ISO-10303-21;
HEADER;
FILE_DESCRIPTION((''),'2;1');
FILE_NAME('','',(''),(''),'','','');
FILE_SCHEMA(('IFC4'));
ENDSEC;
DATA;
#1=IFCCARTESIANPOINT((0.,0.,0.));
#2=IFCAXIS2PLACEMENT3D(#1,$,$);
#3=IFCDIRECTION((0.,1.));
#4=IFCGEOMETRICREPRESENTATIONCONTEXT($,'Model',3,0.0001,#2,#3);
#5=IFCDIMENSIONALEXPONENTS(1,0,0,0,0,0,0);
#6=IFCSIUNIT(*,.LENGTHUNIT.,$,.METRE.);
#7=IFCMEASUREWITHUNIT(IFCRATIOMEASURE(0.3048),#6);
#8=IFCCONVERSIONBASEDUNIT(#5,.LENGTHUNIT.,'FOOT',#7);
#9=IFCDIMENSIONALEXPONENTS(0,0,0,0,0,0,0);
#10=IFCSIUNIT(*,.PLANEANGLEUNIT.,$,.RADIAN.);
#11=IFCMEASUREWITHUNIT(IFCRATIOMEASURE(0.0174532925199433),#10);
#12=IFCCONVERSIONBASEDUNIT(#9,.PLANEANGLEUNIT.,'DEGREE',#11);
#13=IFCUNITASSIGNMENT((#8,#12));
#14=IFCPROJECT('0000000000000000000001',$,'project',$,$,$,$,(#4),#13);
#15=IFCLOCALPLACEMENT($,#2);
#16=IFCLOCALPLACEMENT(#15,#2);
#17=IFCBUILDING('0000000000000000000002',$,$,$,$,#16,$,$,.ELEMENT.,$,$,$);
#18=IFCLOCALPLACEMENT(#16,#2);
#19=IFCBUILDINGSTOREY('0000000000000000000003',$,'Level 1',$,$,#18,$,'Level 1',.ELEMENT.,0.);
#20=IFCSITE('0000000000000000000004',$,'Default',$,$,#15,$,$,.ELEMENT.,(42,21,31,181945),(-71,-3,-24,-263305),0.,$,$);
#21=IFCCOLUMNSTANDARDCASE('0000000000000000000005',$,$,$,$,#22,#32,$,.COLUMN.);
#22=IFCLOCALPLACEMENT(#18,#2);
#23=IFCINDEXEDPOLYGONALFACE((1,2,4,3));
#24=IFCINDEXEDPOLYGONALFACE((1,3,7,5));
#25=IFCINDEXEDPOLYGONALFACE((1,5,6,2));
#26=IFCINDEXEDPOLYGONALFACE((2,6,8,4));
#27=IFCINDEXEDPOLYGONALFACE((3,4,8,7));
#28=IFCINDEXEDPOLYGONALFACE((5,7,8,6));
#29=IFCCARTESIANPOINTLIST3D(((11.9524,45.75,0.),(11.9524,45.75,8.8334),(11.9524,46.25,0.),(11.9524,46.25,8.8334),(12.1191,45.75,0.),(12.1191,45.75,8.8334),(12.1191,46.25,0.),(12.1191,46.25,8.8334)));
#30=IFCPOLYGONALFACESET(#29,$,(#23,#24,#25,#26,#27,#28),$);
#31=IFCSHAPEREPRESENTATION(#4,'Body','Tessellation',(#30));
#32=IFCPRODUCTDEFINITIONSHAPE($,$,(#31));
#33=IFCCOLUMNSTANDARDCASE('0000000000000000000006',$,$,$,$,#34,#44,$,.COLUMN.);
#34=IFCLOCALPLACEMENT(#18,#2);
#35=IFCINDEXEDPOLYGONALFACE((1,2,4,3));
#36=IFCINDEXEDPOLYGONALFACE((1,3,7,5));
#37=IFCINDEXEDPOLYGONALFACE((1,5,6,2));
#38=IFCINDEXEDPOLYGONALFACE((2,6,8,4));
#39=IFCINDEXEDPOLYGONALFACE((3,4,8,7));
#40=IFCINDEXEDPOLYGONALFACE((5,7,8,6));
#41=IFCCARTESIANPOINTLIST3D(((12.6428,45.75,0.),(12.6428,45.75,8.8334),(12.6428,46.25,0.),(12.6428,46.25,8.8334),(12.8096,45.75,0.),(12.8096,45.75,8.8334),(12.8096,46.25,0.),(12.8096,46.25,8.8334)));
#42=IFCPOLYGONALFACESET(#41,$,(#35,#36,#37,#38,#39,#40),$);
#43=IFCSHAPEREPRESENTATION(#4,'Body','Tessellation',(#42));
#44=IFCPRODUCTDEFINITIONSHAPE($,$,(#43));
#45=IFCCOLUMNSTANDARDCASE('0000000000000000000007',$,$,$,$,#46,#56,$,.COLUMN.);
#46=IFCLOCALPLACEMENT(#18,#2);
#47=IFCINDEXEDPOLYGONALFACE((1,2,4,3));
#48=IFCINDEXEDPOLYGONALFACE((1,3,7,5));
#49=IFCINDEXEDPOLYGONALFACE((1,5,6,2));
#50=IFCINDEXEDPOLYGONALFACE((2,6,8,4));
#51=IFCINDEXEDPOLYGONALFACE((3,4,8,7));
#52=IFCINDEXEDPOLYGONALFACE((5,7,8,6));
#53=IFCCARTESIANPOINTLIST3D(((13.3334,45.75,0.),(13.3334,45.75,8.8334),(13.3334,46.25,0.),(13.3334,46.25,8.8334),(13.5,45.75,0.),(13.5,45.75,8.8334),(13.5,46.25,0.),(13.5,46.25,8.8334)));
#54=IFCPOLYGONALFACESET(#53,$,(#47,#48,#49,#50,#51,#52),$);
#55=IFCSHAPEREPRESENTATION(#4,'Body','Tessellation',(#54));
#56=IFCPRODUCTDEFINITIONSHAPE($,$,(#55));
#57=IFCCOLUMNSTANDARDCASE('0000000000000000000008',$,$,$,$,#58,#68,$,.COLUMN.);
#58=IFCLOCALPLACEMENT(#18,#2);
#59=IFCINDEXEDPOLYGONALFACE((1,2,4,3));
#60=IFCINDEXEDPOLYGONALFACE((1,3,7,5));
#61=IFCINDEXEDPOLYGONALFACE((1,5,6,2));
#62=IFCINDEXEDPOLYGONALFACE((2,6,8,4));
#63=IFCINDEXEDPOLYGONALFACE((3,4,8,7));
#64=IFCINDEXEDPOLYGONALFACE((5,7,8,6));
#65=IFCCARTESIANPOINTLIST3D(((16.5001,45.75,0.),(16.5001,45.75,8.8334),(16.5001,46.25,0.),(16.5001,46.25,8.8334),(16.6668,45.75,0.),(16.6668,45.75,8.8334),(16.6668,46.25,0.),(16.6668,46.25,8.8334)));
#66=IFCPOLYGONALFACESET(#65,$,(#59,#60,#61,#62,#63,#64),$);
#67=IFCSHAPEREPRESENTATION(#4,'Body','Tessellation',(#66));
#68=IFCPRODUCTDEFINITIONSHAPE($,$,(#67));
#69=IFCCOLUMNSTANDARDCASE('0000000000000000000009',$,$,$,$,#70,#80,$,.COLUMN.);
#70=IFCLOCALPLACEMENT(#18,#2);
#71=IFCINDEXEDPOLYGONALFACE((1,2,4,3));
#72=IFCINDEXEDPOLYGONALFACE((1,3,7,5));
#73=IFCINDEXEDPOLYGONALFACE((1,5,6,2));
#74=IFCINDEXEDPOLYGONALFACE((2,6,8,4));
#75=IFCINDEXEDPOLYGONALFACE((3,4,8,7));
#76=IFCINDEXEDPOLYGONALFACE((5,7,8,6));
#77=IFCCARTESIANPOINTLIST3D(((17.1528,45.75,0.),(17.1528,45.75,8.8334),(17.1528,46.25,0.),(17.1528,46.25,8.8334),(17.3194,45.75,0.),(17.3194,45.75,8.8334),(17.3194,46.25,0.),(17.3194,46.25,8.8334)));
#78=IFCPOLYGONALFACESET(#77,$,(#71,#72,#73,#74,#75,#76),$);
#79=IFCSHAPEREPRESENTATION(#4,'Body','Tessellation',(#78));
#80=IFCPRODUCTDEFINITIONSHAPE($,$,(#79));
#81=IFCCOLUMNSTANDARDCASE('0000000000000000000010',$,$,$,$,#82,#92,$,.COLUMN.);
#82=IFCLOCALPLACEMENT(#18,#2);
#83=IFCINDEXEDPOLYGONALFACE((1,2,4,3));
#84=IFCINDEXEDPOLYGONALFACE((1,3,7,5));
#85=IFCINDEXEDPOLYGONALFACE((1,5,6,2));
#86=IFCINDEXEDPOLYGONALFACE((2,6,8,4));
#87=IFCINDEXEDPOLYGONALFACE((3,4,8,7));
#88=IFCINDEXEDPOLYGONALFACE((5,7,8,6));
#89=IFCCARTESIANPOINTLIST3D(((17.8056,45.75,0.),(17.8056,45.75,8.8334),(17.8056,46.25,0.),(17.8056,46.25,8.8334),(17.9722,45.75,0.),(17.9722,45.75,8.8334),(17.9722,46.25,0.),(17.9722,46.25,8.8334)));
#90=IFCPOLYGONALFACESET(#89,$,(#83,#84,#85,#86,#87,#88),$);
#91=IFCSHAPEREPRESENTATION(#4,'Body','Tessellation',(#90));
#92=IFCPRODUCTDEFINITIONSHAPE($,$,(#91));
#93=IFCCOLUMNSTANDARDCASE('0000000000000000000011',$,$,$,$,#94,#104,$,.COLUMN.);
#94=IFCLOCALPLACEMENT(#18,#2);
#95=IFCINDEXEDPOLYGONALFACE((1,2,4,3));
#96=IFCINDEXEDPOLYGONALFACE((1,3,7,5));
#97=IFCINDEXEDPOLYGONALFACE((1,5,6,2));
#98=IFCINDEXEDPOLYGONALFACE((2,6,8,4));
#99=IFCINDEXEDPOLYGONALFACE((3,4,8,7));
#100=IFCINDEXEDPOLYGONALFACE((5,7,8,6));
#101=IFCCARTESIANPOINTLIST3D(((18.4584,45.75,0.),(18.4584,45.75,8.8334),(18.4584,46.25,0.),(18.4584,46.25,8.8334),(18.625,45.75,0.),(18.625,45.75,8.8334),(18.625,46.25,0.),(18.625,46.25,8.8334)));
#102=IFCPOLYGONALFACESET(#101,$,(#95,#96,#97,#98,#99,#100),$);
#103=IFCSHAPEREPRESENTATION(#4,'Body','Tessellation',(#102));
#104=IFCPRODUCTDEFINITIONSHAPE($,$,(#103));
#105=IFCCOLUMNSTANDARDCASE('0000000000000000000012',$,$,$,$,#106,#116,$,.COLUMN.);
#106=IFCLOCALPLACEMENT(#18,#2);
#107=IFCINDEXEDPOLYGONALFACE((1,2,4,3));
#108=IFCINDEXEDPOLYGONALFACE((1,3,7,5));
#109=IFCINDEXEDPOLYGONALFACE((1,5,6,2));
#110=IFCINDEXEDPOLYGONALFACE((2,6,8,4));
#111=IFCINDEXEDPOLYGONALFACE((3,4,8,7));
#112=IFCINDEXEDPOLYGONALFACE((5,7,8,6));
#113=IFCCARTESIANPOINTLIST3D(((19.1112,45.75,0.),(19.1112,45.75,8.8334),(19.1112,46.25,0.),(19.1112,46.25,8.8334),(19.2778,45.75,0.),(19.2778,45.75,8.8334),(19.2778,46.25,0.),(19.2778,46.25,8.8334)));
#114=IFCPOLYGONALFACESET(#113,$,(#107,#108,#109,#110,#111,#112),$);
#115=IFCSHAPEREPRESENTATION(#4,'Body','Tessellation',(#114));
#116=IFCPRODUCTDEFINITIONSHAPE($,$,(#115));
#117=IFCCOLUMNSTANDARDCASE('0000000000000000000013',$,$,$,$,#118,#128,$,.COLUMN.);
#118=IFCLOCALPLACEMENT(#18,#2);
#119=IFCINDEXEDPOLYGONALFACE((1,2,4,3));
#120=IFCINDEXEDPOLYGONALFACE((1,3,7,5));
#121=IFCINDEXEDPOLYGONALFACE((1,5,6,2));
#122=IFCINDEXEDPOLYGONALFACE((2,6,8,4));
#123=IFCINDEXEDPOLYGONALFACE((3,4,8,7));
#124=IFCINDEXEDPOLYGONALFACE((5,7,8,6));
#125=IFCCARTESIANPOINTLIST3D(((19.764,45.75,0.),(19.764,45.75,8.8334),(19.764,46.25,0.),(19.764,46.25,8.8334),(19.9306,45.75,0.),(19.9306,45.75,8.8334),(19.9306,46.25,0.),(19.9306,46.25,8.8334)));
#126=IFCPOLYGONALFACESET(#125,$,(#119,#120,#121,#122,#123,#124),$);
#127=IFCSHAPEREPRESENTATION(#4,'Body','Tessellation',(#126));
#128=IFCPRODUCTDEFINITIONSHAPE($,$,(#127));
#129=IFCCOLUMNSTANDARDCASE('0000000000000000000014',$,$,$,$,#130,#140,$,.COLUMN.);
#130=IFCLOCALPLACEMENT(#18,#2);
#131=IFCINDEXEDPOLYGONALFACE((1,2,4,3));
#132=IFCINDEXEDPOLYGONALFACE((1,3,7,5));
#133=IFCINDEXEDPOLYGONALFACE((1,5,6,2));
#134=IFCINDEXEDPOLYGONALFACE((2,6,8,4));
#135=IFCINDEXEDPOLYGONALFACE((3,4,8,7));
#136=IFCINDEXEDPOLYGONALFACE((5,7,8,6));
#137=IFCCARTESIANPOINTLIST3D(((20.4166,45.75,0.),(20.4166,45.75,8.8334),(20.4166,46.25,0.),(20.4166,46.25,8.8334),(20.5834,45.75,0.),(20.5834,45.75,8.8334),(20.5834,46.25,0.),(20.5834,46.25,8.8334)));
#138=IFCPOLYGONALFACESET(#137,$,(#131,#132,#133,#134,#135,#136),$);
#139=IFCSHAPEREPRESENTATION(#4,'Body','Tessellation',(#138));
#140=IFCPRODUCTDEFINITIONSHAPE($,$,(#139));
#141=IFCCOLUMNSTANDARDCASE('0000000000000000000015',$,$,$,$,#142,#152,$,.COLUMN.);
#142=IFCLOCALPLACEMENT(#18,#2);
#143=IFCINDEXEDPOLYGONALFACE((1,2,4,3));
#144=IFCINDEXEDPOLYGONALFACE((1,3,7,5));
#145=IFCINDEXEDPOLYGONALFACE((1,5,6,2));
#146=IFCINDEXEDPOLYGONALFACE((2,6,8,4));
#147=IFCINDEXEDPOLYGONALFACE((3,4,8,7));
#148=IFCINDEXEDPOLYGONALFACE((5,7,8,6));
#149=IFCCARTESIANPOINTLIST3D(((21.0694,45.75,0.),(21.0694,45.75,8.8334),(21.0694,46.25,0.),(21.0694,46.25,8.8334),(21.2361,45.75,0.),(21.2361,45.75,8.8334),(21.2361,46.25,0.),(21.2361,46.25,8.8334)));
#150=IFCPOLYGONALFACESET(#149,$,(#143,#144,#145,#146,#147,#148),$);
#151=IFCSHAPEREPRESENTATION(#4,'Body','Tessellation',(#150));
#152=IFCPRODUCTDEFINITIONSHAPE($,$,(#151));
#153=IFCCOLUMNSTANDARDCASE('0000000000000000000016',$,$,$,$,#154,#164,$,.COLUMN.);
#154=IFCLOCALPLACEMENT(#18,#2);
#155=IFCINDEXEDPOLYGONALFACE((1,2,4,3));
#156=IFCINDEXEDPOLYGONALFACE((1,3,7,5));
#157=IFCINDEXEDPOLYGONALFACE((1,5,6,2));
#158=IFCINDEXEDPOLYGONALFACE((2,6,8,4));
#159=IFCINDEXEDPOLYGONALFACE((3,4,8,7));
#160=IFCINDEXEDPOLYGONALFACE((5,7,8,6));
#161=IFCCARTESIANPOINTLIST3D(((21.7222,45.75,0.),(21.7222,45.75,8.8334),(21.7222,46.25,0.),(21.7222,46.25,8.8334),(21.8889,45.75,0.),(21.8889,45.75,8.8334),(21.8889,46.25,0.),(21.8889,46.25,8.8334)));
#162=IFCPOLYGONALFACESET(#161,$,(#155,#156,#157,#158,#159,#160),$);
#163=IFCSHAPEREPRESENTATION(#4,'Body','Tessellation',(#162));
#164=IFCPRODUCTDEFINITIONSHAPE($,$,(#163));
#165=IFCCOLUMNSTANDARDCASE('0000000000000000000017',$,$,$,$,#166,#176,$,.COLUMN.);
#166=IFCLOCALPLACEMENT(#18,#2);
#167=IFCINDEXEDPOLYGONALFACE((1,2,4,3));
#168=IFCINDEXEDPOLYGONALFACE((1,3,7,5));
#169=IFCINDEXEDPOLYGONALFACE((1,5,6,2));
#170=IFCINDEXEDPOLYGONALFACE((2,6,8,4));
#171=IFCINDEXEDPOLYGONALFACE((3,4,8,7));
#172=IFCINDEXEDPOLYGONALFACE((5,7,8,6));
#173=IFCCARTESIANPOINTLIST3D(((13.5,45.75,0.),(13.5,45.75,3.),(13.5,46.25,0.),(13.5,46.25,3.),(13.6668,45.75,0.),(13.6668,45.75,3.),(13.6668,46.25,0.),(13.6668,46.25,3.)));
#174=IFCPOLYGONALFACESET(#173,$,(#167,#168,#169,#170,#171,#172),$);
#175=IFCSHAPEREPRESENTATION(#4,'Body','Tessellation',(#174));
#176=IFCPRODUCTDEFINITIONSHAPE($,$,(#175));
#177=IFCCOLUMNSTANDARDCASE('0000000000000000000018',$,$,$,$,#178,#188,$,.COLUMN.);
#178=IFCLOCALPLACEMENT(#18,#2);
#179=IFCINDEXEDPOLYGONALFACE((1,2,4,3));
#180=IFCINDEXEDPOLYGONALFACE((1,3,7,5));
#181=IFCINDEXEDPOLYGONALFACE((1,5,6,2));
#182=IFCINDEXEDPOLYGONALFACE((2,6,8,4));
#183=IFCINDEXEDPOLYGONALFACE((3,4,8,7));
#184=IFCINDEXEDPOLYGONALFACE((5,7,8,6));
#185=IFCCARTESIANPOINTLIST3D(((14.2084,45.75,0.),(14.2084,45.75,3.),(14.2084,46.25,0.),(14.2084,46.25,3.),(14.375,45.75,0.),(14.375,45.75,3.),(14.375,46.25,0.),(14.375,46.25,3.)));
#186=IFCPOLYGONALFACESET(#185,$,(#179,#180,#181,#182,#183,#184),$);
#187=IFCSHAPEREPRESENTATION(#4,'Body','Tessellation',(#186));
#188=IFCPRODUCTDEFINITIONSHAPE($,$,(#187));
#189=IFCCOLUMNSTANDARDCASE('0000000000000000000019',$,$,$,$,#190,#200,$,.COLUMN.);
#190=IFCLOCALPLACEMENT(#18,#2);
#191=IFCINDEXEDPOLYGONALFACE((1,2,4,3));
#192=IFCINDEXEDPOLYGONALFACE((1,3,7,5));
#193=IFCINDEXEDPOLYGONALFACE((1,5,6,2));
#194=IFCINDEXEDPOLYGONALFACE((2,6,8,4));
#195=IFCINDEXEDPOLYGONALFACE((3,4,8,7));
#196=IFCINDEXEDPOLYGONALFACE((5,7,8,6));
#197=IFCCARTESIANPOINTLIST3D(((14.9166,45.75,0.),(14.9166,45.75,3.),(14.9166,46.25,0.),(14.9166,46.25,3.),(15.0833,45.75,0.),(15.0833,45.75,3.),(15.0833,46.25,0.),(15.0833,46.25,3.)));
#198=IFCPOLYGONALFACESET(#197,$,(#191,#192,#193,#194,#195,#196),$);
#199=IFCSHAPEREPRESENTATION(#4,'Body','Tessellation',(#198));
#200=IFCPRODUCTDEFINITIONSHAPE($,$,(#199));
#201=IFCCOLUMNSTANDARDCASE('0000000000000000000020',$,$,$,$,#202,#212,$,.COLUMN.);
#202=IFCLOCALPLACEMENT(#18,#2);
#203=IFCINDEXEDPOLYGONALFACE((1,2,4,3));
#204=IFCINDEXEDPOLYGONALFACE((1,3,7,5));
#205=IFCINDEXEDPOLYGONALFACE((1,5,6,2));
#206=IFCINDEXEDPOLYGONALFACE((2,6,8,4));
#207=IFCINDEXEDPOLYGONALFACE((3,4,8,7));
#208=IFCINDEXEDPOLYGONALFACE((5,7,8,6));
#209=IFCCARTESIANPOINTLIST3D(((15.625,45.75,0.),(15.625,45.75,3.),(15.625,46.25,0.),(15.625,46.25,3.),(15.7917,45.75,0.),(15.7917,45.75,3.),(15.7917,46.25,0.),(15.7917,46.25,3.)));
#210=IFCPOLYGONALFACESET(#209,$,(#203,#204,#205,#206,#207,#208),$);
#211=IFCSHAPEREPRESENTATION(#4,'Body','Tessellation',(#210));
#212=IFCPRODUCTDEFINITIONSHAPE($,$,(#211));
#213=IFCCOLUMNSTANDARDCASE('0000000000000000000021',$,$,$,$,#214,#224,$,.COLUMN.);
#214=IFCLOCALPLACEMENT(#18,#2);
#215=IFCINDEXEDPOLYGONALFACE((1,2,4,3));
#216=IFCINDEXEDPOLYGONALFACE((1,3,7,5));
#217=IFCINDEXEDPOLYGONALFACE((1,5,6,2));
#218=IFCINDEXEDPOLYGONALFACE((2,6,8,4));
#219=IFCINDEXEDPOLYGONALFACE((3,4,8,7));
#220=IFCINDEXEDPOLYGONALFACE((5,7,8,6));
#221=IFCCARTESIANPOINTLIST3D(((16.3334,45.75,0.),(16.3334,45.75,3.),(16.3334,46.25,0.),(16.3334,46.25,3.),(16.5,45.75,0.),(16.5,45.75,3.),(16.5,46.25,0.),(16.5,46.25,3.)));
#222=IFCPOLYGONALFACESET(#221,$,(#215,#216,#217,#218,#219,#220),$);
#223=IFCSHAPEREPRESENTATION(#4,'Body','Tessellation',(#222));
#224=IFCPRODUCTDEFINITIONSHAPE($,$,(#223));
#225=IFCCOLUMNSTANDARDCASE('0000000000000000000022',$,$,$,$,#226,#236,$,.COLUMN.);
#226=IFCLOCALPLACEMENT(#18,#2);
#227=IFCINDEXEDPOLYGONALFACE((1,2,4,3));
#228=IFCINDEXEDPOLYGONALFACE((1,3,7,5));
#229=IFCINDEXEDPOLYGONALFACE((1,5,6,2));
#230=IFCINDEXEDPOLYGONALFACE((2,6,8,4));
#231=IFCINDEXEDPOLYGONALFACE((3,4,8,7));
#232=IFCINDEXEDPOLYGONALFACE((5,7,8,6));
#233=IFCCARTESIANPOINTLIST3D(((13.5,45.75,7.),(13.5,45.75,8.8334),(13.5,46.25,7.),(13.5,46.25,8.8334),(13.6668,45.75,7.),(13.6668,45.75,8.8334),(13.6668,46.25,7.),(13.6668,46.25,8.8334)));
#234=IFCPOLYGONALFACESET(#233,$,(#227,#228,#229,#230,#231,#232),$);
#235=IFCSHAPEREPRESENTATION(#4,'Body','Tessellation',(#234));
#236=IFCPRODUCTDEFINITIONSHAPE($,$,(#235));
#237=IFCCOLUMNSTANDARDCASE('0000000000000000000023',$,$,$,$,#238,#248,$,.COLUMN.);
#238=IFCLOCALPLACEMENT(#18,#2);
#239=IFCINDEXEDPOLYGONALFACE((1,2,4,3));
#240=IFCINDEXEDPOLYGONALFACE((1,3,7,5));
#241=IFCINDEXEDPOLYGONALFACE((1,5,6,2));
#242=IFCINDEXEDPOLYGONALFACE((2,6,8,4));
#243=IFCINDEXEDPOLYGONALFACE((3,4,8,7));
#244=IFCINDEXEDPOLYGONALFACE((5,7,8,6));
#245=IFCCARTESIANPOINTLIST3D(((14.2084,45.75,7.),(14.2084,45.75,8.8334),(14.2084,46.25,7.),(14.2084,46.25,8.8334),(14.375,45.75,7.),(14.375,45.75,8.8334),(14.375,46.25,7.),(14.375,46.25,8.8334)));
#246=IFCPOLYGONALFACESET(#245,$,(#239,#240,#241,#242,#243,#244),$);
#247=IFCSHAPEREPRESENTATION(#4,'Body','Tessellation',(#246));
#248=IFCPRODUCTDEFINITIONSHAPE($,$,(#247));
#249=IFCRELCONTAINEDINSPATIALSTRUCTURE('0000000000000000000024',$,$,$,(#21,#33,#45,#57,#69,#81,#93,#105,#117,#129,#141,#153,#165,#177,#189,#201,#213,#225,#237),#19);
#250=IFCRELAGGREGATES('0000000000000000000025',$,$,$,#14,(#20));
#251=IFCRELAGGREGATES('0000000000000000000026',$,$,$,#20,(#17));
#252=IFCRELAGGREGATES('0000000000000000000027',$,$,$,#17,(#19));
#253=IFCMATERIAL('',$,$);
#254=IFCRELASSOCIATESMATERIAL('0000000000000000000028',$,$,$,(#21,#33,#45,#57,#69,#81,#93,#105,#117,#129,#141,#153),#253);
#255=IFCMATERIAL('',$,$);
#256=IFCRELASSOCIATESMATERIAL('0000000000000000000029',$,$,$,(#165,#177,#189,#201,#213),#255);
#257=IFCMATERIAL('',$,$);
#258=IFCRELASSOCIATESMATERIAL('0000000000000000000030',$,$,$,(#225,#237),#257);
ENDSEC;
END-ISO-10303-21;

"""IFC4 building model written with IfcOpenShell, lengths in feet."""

from ifc_helpers import new_model, entity, si_unit, converted_unit, direction, frame, origin, place, context, project, spatial, rectangle, extrude, material, element, save


model = new_model("IFC4")

# Units and contexts
model_context = context("Model", 3, precision=0.0001, world=origin(), true_north=direction((0.0, 1.0)))
ifc_project = project(units=[converted_unit("LENGTHUNIT", "FOOT", entity("IfcRatioMeasure", 0.3048), si_unit("LENGTHUNIT", "METRE"), dimensions=[1, 0, 0, 0, 0, 0, 0]), converted_unit("PLANEANGLEUNIT", "DEGREE", entity("IfcRatioMeasure", 0.0174532925199433), si_unit("PLANEANGLEUNIT", "RADIAN"), dimensions=[0, 0, 0, 0, 0, 0, 0])], contexts=[model_context])

# Site, building, storey
site_placement = place(None, origin())
site = spatial("IfcSite", under=ifc_project, at=site_placement, Name="Default", CompositionType="ELEMENT", RefLatitude=(42, 21, 31, 181945), RefLongitude=(-71, -3, -24, -263305), RefElevation=0.0)
building_placement = place(site_placement, origin())
building = spatial("IfcBuilding", under=site, at=building_placement, CompositionType="ELEMENT")
storey_placement = place(building_placement, origin())
storey = spatial("IfcBuildingStorey", under=building, at=storey_placement, Name="Level 1", LongName="Level 1", CompositionType="ELEMENT", Elevation=0.0)

# Columns
ifc_material_1 = material(Name="")
placement_1 = place(storey_placement, frame((-0.25, 46.0, 0.0)))
for number, where, z_axis, x_axis in (
    (1, (12.2857, 0.0, 0.0), (0.0, 0.0, 1.0), (1.0, 0.0, 0.0)),
    (2, (12.9762, 0.0, 0.0), (0.0, 0.0, 1.0), (1.0, 0.0, 0.0)),
    (3, (13.6667, 0.0, 0.0), (0.0, 0.0, 1.0), (1.0, 0.0, 0.0)),
    (4, (16.8334, 0.0, 0.0), (0.0, 0.0, 1.0), (1.0, 0.0, 0.0)),
    (5, (17.4861, 0.0, 0.0), (0.0, 0.0, 1.0), (1.0, 0.0, 0.0)),
    (6, (18.1389, 0.0, 0.0), (0.0, 0.0, 1.0), (1.0, 0.0, 0.0)),
    (7, (18.7917, 0.0, 0.0), (0.0, 0.0, 1.0), (1.0, 0.0, 0.0)),
    (8, (19.4445, 0.0, 0.0), (0.0, 0.0, 1.0), (1.0, 0.0, 0.0)),
    (9, (20.0973, 0.0, 0.0), (0.0, 0.0, 1.0), (1.0, 0.0, 0.0)),
    (10, (20.75, 0.0, 0.0), (0.0, 0.0, 1.0), (1.0, 0.0, 0.0)),
    (11, (21.4028, 0.0, 0.0), (0.0, 0.0, 1.0), (1.0, 0.0, 0.0)),
    (12, (22.0556, 0.0, 0.0), (0.0, 0.0, 1.0), (1.0, 0.0, 0.0)),
):
    element("IfcColumnStandardCase", number, at=place(placement_1, frame(where, z_axis=z_axis, x_axis=x_axis)), inside=storey, material=ifc_material_1, PredefinedType="COLUMN", context=model_context, shape_type="SweptSolid", body=[
        extrude(rectangle(XDim=0.1667, YDim=0.5), origin(), (0.0, 0.0, 1.0), 8.8334),
    ])
ifc_material_2 = material(Name="")
for number, where, z_axis, x_axis in (
    (13, (13.8334, 0.0, 0.0), (0.0, 0.0, 1.0), (1.0, 0.0, 0.0)),
    (14, (14.5417, 0.0, 0.0), (0.0, 0.0, 1.0), (1.0, 0.0, 0.0)),
    (15, (15.25, 0.0, 0.0), (0.0, 0.0, 1.0), (1.0, 0.0, 0.0)),
    (16, (15.9584, 0.0, 0.0), (0.0, 0.0, 1.0), (1.0, 0.0, 0.0)),
    (17, (16.6667, 0.0, 0.0), (0.0, 0.0, 1.0), (1.0, 0.0, 0.0)),
):
    element("IfcColumnStandardCase", number, at=place(placement_1, frame(where, z_axis=z_axis, x_axis=x_axis)), inside=storey, material=ifc_material_2, PredefinedType="COLUMN", context=model_context, shape_type="SweptSolid", body=[
        extrude(rectangle(XDim=0.1667, YDim=0.5), origin(), (0.0, 0.0, 1.0), 3.0),
    ])
ifc_material_3 = material(Name="")
for number, where, z_axis, x_axis in (
    (18, (13.8334, 0.0, 7.0), (0.0, 0.0, 1.0), (1.0, 0.0, 0.0)),
    (19, (14.5417, 0.0, 7.0), (0.0, 0.0, 1.0), (1.0, 0.0, 0.0)),
):
    element("IfcColumnStandardCase", number, at=place(placement_1, frame(where, z_axis=z_axis, x_axis=x_axis)), inside=storey, material=ifc_material_3, PredefinedType="COLUMN", context=model_context, shape_type="SweptSolid", body=[
        extrude(rectangle(XDim=0.1667, YDim=0.5), origin(), (0.0, 0.0, 1.0), 1.8334),
    ])

save(model, "model.ifc")
